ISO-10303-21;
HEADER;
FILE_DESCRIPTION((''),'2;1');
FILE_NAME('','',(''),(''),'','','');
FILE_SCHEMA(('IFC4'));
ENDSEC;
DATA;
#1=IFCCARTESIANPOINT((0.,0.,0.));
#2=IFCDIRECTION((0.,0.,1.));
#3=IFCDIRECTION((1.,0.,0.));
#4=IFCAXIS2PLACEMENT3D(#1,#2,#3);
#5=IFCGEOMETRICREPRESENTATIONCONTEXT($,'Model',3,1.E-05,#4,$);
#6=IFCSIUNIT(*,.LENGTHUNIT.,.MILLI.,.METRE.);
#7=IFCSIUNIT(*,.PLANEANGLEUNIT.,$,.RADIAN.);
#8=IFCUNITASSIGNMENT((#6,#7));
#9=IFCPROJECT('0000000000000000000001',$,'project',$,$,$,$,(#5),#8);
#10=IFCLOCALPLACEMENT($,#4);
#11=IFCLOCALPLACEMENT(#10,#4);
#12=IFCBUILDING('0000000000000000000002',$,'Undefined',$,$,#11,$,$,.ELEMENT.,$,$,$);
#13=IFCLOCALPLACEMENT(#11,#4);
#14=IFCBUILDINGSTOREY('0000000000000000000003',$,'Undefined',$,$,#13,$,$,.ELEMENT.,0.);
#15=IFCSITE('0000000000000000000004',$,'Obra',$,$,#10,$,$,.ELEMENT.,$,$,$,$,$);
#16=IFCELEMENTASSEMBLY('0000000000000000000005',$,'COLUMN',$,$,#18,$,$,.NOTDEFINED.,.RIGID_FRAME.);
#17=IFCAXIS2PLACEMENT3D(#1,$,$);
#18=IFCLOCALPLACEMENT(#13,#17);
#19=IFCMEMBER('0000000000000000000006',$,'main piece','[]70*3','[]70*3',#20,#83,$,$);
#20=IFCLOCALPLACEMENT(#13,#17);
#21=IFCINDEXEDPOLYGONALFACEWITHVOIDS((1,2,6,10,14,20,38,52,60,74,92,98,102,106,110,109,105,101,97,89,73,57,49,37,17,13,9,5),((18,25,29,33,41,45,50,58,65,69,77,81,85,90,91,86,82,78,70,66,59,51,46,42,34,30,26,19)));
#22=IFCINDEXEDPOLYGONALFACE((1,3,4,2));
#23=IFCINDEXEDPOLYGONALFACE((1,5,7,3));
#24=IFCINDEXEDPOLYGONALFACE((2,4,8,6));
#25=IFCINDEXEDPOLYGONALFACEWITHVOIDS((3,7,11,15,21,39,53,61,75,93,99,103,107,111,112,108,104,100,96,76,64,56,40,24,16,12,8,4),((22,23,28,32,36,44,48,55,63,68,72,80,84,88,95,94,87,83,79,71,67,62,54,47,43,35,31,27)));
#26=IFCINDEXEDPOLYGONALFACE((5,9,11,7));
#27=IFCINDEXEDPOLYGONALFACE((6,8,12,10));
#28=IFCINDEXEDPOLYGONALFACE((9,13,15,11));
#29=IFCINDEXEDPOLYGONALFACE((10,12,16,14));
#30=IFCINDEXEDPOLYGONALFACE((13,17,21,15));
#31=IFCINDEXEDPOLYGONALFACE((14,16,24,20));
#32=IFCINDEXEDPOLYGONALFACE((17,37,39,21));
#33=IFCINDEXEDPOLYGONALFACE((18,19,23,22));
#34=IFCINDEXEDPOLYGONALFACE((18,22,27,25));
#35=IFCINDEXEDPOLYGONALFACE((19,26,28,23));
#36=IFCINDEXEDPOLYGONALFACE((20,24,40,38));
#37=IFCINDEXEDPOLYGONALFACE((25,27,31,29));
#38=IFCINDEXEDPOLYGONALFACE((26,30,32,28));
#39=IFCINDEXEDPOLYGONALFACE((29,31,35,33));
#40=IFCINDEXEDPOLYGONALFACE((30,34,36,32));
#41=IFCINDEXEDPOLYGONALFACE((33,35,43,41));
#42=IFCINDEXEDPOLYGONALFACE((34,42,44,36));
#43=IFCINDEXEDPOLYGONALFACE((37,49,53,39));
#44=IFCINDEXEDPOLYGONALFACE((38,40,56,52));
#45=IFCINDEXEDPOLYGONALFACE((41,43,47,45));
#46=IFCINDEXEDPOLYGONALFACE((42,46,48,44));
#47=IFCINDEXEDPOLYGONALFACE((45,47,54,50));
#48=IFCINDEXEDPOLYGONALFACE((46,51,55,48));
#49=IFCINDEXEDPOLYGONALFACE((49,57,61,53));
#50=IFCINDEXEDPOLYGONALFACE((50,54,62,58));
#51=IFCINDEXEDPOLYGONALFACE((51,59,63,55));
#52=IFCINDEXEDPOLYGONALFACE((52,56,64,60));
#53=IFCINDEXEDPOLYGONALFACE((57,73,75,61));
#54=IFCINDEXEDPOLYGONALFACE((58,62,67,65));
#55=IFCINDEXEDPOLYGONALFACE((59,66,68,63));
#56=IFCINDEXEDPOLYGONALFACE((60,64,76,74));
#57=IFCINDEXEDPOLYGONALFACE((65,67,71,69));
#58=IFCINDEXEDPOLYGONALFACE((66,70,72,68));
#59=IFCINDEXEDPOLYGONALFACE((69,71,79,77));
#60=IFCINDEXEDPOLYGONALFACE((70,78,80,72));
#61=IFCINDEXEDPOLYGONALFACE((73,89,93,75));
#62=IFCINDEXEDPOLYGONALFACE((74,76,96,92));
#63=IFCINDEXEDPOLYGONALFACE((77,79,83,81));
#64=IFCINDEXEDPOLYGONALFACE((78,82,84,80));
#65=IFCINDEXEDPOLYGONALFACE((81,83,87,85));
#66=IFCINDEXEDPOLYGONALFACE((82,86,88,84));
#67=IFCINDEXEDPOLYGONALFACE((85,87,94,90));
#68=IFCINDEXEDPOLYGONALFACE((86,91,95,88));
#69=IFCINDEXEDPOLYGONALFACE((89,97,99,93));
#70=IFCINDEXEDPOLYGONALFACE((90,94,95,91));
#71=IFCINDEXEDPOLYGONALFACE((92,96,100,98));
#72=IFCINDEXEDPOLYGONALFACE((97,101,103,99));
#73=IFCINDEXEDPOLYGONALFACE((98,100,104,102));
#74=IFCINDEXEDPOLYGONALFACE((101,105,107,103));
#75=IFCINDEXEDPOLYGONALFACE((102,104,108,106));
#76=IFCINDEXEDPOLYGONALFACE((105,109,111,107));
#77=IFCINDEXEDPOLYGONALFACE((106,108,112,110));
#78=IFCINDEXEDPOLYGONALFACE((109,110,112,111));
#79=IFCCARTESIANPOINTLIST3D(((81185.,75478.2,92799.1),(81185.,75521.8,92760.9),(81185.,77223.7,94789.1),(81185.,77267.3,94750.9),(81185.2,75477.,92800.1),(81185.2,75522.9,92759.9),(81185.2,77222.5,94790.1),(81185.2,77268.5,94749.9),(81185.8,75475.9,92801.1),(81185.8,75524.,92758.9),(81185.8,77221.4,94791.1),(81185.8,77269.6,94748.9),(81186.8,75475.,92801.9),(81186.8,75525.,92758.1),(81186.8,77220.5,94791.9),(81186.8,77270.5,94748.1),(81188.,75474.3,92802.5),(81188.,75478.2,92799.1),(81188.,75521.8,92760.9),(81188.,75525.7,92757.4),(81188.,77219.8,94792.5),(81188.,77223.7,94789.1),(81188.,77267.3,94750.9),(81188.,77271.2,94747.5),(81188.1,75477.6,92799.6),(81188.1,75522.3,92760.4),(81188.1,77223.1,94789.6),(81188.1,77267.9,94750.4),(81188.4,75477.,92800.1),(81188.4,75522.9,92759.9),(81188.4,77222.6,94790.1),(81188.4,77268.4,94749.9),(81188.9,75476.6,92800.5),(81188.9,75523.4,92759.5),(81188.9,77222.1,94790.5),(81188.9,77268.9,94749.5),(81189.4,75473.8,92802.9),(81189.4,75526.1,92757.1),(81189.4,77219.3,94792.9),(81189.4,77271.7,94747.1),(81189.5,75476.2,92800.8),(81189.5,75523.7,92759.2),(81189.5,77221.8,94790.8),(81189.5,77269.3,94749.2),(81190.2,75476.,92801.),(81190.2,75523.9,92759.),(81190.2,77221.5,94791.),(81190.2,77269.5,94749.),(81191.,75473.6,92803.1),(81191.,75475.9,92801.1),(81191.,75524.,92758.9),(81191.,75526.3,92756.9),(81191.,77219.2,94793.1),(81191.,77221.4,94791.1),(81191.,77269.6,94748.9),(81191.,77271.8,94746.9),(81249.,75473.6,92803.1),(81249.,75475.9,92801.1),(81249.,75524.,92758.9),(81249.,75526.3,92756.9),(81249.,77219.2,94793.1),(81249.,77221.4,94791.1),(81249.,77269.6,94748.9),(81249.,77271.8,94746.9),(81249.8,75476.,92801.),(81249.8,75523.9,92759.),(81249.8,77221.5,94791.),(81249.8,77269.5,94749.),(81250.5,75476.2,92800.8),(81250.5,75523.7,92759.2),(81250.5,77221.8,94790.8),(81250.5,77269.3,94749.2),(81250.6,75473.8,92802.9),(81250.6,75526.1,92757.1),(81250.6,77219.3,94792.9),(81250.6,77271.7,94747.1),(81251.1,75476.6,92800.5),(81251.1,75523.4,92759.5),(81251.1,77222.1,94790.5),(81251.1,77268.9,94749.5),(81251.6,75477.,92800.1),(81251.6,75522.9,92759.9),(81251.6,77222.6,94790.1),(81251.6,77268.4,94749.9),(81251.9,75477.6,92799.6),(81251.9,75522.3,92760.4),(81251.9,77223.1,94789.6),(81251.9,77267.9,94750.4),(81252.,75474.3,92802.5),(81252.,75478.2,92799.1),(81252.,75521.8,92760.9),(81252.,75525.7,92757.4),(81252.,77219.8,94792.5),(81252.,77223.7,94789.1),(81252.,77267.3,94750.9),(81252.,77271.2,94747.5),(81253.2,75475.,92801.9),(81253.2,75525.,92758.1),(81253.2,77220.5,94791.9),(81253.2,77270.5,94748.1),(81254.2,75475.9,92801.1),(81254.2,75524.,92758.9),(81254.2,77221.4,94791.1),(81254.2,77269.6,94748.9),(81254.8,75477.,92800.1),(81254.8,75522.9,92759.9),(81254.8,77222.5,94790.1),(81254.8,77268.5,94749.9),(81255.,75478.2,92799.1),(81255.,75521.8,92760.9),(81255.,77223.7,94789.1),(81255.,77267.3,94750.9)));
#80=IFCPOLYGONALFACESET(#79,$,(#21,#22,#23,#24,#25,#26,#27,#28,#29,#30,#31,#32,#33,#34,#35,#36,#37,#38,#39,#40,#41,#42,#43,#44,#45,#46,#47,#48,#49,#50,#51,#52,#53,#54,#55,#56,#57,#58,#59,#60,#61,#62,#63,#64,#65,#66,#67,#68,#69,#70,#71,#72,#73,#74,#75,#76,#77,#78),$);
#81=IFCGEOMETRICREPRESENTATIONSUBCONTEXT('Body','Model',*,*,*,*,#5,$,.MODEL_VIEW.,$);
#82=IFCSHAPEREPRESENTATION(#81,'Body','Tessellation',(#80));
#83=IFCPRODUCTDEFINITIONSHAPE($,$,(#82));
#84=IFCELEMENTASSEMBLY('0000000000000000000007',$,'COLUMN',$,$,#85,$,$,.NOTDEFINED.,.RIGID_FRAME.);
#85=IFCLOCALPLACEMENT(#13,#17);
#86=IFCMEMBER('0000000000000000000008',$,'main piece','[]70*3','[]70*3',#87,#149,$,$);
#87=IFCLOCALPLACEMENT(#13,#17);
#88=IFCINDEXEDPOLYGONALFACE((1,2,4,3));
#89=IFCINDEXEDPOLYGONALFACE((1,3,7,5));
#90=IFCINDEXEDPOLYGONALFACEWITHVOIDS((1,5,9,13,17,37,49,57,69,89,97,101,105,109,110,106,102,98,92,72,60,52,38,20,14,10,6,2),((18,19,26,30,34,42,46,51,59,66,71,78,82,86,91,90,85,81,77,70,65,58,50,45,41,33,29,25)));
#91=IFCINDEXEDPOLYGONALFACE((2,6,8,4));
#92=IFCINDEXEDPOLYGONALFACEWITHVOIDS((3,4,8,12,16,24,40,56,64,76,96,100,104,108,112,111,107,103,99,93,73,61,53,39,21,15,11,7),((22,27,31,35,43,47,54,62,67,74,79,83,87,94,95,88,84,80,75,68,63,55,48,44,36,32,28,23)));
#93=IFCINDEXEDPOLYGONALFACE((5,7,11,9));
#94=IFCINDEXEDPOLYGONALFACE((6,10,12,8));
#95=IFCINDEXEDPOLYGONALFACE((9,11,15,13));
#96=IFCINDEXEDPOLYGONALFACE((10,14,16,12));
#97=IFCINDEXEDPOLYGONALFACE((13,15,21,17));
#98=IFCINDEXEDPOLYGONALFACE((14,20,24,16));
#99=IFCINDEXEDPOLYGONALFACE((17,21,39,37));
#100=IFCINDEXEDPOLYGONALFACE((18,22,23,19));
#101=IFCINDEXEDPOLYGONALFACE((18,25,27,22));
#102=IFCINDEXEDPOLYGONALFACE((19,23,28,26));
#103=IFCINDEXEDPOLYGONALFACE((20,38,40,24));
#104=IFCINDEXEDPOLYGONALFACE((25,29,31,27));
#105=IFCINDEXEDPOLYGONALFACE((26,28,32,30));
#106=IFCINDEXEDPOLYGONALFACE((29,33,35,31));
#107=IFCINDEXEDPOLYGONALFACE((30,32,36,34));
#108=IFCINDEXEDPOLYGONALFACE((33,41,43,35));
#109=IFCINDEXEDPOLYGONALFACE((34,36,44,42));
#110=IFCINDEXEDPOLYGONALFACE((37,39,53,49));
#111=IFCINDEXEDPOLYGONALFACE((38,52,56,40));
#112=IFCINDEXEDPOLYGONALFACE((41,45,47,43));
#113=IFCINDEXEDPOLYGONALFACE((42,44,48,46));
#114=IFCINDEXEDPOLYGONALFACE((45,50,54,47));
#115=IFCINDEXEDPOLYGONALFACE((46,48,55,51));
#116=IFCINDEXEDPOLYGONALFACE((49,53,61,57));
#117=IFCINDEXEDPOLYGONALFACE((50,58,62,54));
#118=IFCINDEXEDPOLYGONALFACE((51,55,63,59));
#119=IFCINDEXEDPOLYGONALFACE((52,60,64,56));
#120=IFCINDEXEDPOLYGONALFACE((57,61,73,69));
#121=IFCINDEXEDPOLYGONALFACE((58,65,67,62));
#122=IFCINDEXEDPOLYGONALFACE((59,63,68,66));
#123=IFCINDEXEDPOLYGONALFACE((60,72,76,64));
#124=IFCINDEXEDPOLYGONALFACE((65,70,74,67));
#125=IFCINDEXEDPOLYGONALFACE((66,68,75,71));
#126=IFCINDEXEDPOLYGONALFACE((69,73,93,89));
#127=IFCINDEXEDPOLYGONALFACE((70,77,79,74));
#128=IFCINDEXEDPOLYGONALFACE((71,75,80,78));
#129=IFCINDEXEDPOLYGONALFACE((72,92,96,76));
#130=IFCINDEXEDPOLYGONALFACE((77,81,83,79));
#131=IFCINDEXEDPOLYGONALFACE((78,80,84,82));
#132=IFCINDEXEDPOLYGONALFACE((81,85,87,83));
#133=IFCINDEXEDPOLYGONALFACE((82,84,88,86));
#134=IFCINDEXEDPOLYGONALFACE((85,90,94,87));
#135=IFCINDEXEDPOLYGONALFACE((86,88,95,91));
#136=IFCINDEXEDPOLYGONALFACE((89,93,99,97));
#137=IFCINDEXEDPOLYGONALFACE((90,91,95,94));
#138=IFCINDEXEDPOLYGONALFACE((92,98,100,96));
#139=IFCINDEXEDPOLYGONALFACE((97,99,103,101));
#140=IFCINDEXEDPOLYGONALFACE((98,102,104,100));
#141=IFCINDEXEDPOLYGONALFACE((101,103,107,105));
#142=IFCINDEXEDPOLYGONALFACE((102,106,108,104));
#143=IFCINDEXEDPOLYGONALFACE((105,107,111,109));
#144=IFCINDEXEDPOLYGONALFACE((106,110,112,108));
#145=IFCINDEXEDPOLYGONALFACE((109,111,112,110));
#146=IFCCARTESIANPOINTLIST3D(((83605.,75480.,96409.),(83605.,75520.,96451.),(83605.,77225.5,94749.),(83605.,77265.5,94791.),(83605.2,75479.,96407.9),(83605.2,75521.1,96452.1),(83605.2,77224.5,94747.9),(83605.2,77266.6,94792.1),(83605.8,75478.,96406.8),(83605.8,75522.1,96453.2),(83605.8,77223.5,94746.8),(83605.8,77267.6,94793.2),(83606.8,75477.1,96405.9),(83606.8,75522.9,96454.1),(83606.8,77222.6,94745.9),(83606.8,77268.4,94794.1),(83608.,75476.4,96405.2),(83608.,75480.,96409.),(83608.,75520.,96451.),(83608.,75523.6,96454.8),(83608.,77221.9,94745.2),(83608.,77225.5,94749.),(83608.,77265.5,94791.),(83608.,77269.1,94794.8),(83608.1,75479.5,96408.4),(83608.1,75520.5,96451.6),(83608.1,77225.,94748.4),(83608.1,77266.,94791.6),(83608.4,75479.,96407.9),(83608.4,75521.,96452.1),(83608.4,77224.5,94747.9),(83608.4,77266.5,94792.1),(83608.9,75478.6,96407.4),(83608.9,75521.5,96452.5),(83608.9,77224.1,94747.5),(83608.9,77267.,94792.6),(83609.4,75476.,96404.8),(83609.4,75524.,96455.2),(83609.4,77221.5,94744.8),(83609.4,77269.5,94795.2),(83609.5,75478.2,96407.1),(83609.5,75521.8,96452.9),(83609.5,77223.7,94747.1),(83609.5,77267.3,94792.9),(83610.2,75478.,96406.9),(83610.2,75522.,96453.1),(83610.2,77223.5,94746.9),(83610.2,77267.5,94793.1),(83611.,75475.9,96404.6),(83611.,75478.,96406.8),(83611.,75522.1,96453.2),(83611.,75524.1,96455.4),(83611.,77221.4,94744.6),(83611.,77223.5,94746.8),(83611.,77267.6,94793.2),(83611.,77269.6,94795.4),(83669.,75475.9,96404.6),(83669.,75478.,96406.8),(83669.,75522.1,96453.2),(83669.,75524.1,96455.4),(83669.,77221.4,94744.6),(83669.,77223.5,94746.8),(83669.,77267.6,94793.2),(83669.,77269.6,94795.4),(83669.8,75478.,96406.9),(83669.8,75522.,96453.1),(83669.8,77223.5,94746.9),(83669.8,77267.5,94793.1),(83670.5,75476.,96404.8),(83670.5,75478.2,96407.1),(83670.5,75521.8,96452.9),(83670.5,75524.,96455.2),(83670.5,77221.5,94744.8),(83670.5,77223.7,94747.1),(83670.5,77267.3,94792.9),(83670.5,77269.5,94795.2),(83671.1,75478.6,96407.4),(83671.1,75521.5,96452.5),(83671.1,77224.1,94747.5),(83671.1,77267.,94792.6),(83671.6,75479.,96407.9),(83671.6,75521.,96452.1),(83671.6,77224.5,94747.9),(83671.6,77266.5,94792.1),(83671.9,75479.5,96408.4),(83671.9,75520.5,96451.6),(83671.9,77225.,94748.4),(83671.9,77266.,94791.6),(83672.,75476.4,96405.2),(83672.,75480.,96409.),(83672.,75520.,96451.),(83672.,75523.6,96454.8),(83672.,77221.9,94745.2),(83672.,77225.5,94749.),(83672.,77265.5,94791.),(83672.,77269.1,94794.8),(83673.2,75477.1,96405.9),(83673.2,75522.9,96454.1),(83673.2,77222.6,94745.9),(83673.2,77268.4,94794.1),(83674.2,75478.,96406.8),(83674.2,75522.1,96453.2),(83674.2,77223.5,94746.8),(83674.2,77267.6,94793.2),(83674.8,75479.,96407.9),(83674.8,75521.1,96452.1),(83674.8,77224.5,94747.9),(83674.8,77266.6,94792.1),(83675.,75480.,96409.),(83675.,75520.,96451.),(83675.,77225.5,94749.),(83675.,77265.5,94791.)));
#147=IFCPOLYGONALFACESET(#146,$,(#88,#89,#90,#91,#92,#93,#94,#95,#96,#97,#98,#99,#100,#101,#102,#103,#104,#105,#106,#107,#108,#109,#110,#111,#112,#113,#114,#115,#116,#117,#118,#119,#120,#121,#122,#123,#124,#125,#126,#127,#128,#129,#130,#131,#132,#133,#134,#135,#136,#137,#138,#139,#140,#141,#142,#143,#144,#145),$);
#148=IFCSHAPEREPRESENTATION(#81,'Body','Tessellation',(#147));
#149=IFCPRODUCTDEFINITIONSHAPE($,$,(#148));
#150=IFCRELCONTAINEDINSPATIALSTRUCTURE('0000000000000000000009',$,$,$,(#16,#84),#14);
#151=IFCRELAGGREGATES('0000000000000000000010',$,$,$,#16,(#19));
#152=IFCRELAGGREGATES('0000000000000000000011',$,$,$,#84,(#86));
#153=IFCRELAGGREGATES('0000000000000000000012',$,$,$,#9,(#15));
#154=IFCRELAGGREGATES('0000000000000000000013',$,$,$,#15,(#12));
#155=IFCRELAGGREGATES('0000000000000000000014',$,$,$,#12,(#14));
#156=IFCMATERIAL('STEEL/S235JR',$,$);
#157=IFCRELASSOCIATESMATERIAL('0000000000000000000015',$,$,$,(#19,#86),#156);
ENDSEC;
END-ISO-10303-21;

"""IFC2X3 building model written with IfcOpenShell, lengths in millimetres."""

from ifc_helpers import new_model, si_unit, frame, origin_with_axes, origin_2d_with_axis, place, context, subcontext, project, spatial, hollow_rectangle, extrude, material, element, aggregate, save


model = new_model("IFC2X3")

# Units and contexts
model_context = context("Model", 3, precision=1e-05, world=origin_with_axes())
body_context = subcontext(model_context, "Body", "Model", "MODEL_VIEW")
ifc_project = project(units=[si_unit("LENGTHUNIT", "METRE", prefix="MILLI"), si_unit("PLANEANGLEUNIT", "RADIAN")], contexts=[model_context])

# Site, building, storey
site_placement = place(None, origin_with_axes())
site = spatial("IfcSite", under=ifc_project, at=site_placement, Name="Obra", CompositionType="ELEMENT")
building_placement = place(site_placement, origin_with_axes())
building = spatial("IfcBuilding", under=site, at=building_placement, Name="Undefined", CompositionType="ELEMENT")
storey_placement = place(building_placement, origin_with_axes())
storey = spatial("IfcBuildingStorey", under=building, at=storey_placement, Name="Undefined", CompositionType="ELEMENT", Elevation=0.0)

# Shared definitions
ifc_material = material(Name="STEEL/S235JR")

# Element assemblies, members
assembly_1_placement = place(storey_placement, origin_with_axes())
assembly_1 = element("IfcElementAssembly", 1, at=assembly_1_placement, inside=storey, Name="COLUMN", AssemblyPlace="NOTDEFINED", PredefinedType="RIGID_FRAME")
member_1_placement = place(assembly_1_placement, frame((81220.0, 75500.0, 92780.0), z_axis=(-1.0, 0.0, 0.0), x_axis=(0.0, 0.659423, 0.751772)))
member_1 = element("IfcMember", 2, at=member_1_placement, material=ifc_material, Name="main piece", Description="[]70*3", ObjectType="[]70*3", context=body_context, shape_type="SweptSolid", body=[
    extrude(hollow_rectangle(XDim=70.0, YDim=70.0, WallThickness=3.0, InnerFilletRadius=3.0, OuterFilletRadius=6.0, at=origin_2d_with_axis()), frame((2647.1, 0.0, 0.0), z_axis=(-1.0, 0.0, 0.0), x_axis=(0.0, -1.0, 0.0)), (0.0, 0.0, 1.0), 2647.1),
])
aggregate(assembly_1, [member_1])
assembly_2_placement = place(storey_placement, origin_with_axes())
assembly_2 = element("IfcElementAssembly", 3, at=assembly_2_placement, inside=storey, Name="COLUMN", AssemblyPlace="NOTDEFINED", PredefinedType="RIGID_FRAME")
member_2_placement = place(assembly_2_placement, frame((83640.0, 77245.5, 94770.0), z_axis=(1.0, 0.0, 0.0), x_axis=(0.0, -0.724633, 0.689135)))
member_2 = element("IfcMember", 4, at=member_2_placement, material=ifc_material, Name="main piece", Description="[]70*3", ObjectType="[]70*3", context=body_context, shape_type="SweptSolid", body=[
    extrude(hollow_rectangle(XDim=70.0, YDim=70.0, WallThickness=3.0, InnerFilletRadius=3.0, OuterFilletRadius=6.0, at=origin_2d_with_axis()), frame((2408.8, 0.0, 0.0), z_axis=(-1.0, 0.0, 0.0), x_axis=(0.0, -1.0, 0.0)), (0.0, 0.0, 1.0), 2408.8),
])
aggregate(assembly_2, [member_2])

save(model, "model.ifc")
